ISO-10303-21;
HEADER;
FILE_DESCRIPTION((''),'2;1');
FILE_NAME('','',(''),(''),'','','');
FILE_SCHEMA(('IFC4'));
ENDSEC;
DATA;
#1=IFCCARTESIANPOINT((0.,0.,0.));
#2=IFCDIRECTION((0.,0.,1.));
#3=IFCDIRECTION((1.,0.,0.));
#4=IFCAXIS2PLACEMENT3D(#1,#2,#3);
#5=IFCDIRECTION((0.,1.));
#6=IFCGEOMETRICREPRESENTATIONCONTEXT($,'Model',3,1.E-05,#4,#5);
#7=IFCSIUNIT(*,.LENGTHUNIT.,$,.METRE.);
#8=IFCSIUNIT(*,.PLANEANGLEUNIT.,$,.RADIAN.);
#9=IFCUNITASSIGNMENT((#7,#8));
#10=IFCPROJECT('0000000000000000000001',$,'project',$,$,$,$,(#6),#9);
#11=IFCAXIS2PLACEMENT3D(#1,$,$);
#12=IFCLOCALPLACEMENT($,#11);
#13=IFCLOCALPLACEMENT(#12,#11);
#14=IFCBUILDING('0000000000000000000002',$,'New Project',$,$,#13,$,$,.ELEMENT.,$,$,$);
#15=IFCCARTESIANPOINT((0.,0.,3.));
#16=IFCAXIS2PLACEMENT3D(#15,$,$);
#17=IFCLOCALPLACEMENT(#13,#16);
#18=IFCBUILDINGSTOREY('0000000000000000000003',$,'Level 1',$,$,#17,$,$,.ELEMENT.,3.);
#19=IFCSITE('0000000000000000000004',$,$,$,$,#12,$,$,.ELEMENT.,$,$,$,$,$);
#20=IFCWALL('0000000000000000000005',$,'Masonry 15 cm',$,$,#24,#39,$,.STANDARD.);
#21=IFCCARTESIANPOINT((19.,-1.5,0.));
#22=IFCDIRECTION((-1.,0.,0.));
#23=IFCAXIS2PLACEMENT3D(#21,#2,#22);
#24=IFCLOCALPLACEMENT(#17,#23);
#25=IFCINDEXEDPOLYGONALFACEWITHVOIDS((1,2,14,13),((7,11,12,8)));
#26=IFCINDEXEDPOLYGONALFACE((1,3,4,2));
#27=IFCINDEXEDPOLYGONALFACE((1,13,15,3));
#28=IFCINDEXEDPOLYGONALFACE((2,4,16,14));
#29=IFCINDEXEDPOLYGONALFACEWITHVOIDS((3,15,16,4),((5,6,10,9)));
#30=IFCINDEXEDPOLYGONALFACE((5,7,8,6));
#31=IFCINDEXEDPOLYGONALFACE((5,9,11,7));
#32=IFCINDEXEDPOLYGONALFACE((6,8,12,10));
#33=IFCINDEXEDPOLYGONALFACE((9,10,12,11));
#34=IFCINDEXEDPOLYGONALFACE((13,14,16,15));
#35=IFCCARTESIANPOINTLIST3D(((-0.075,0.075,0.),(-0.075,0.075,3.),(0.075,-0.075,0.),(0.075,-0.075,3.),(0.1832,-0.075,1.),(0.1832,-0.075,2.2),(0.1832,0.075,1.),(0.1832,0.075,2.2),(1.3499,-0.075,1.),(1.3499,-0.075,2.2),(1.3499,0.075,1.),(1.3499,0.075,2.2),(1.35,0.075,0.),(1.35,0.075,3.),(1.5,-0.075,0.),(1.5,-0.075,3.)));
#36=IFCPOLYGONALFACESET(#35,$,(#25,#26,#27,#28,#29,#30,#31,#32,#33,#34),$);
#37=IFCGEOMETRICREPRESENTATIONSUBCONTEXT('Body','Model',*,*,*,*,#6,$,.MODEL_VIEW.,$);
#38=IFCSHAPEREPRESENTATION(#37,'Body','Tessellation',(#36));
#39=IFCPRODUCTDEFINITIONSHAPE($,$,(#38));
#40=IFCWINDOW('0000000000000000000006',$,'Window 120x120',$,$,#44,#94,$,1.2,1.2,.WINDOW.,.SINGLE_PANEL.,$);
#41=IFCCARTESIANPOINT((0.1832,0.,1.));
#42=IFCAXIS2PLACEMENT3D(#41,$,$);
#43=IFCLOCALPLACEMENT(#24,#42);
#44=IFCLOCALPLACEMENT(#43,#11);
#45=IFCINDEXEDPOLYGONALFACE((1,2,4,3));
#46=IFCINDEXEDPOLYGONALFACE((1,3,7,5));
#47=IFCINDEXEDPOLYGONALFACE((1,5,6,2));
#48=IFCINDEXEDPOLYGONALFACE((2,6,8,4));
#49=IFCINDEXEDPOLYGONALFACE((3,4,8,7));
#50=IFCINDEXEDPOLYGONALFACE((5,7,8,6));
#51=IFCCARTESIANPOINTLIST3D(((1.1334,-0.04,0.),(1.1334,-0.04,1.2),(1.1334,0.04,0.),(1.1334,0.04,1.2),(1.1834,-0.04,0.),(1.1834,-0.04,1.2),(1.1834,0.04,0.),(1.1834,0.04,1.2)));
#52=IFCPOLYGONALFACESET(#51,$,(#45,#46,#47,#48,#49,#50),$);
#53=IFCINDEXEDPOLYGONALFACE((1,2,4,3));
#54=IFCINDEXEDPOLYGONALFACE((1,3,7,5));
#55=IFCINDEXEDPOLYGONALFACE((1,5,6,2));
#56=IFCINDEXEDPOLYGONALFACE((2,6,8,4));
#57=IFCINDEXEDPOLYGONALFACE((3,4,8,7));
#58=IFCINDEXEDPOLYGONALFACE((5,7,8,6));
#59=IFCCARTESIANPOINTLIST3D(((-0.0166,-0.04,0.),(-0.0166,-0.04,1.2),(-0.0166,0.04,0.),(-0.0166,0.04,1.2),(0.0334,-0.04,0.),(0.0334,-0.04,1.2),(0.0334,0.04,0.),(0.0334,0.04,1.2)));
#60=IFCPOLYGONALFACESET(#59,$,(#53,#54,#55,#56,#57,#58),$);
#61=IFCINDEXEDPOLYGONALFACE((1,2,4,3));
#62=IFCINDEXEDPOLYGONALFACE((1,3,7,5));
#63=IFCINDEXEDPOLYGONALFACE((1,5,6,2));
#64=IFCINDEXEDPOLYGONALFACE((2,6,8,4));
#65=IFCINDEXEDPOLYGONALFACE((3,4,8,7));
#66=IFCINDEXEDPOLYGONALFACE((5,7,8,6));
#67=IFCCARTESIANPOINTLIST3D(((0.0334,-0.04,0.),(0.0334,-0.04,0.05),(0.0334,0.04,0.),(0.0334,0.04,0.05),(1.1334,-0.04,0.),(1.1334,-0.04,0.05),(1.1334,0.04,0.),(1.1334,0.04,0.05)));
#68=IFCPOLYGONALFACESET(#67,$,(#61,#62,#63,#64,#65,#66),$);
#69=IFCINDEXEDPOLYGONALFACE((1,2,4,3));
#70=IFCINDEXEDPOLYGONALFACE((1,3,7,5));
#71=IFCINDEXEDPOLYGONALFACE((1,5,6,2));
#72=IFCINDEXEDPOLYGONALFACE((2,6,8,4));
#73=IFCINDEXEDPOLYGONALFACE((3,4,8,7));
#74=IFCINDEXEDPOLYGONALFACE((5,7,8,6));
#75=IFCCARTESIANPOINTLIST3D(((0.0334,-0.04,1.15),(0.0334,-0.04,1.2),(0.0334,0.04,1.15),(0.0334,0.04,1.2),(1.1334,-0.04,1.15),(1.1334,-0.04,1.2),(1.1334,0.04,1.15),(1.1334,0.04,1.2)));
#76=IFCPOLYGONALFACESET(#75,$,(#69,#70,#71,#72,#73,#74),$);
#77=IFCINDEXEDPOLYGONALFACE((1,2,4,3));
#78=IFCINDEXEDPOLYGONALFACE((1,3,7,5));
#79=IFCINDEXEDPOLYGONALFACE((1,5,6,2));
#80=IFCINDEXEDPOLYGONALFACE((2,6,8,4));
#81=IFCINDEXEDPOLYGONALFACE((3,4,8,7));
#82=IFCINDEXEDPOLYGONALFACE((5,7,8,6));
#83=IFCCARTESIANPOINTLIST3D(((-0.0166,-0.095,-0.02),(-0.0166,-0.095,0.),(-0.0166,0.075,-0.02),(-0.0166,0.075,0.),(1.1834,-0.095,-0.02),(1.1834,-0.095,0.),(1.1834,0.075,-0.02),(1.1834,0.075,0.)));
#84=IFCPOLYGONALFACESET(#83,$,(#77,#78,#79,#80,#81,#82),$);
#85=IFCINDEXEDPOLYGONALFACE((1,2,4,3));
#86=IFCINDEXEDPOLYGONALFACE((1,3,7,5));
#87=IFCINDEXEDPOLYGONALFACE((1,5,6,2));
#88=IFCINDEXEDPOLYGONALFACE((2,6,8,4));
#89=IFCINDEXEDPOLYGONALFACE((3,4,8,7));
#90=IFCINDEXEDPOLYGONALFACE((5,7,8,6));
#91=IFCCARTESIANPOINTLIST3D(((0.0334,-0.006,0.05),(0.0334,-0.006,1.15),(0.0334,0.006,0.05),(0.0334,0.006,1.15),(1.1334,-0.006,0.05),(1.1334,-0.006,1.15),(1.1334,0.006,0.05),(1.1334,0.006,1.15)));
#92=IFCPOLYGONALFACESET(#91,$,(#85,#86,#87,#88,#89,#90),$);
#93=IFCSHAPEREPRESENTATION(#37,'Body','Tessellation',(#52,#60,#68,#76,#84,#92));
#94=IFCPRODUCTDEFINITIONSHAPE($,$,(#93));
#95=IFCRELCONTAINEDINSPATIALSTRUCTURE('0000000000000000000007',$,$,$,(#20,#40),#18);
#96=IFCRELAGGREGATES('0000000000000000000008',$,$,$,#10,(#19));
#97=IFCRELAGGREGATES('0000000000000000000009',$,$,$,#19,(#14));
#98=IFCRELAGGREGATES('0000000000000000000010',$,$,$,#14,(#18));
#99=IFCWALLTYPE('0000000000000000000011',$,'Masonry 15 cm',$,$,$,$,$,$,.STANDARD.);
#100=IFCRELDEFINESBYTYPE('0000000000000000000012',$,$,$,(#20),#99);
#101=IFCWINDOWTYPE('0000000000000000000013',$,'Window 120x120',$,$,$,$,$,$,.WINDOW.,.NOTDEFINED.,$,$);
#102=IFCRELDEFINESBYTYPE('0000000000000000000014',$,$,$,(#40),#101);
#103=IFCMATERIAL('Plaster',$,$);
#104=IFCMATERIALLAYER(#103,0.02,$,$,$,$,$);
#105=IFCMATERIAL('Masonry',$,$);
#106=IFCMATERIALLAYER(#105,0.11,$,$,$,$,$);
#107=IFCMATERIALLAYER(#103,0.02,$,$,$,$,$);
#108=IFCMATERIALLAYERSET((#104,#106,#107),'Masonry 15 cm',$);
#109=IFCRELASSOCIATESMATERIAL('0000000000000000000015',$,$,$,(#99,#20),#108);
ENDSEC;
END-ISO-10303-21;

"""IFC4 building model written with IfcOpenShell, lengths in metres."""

from ifc_helpers import new_model, si_unit, direction, frame, frame_2d, origin, origin_with_axes, place, context, subcontext, project, spatial, polyline, rectangle, outline, extrude, material, layer, layer_set, layer_usage, type_object, element, fill, save


model = new_model("IFC4")

# Units and contexts
model_context = context("Model", 3, precision=1e-05, world=origin_with_axes(), true_north=direction((0.0, 1.0)))
body_context = subcontext(model_context, "Body", "Model", "MODEL_VIEW")
ifc_project = project(units=[si_unit("LENGTHUNIT", "METRE"), si_unit("PLANEANGLEUNIT", "RADIAN")], contexts=[model_context])

# Site, building, storey
site_placement = place(None, origin())
site = spatial("IfcSite", under=ifc_project, at=site_placement, CompositionType="ELEMENT")
building_placement = place(site_placement, origin())
building = spatial("IfcBuilding", under=site, at=building_placement, Name="New Project", CompositionType="ELEMENT")
storey_placement = place(building_placement, frame((0.0, 0.0, 3.0)))
storey = spatial("IfcBuildingStorey", under=building, at=storey_placement, Name="Level 1", CompositionType="ELEMENT", Elevation=3.0)

# Shared definitions
ifc_material_1 = material(Name="Plaster")
ifc_layer_1 = layer(ifc_material_1, 0.02)
ifc_material_2 = material(Name="Masonry")
ifc_layer_2 = layer(ifc_material_2, 0.11)
ifc_layer_3 = layer(ifc_material_1, 0.02)
ifc_layer_set_1 = layer_set([ifc_layer_1, ifc_layer_2, ifc_layer_3], Name="Masonry 15 cm")
ifc_layer_usage_1 = layer_usage(ifc_layer_set_1, "AXIS2", "NEGATIVE", 0.075)
wall_type_1 = type_object("IfcWallType", Name="Masonry 15 cm", PredefinedType="STANDARD", material=ifc_layer_set_1)

# Shared definitions
window_type_1 = type_object("IfcWindowType", Name="Window 120x120", PartitioningType="NOTDEFINED", PredefinedType="WINDOW")

# Wall, opening, window
wall_1_placement = place(storey_placement, frame((19.0, -1.5, 0.0), z_axis=(0.0, 0.0, 1.0), x_axis=(-1.0, 0.0, 0.0)))
wall_1 = element("IfcWall", 1, at=wall_1_placement, inside=storey, type_object=wall_type_1, material=ifc_layer_usage_1, Name="Masonry 15 cm", PredefinedType="STANDARD", context=body_context, shape_type="SweptSolid", body=[
    extrude(outline(polyline([(0.075, -0.075), (1.5, -0.075), (1.35, 0.075), (-0.075, 0.075), (0.075, -0.075)])), origin(), (0.0, 0.0, 1.0), 3.0),
])
opening_1_placement = place(wall_1_placement, frame((0.1832, 0.0, 1.0)))
opening_1 = element("IfcOpeningElement", 2, at=opening_1_placement, cuts=wall_1, PredefinedType="OPENING", context=body_context, shape_type="SweptSolid", body=[
    extrude(rectangle(XDim=1.1667, YDim=0.25, at=frame_2d((0.5834, 0.0))), origin(), (0.0, 0.0, 1.0), 1.2),
])
window_1_placement = place(opening_1_placement, origin())
window_1 = element("IfcWindow", 3, at=window_1_placement, inside=storey, type_object=window_type_1, Name="Window 120x120", OverallHeight=1.2, OverallWidth=1.2, PartitioningType="SINGLE_PANEL", PredefinedType="WINDOW", context=body_context, shape_type="SweptSolid", body=[
    extrude(outline(polyline([(1.1834, 0.04), (1.1334, 0.04), (1.1334, -0.04), (1.1834, -0.04), (1.1834, 0.04)])), origin(), (0.0, 0.0, 1.0), 1.2),
    extrude(outline(polyline([(0.0334, 0.04), (-0.0166, 0.04), (-0.0166, -0.04), (0.0334, -0.04), (0.0334, 0.04)])), origin(), (0.0, 0.0, 1.0), 1.2),
    extrude(outline(polyline([(1.1334, 0.04), (0.0334, 0.04), (0.0334, -0.04), (1.1334, -0.04), (1.1334, 0.04)])), origin(), (0.0, 0.0, 1.0), 0.05),
    extrude(outline(polyline([(1.1334, 0.04), (0.0334, 0.04), (0.0334, -0.04), (1.1334, -0.04), (1.1334, 0.04)])), frame((0.0, 0.0, 1.15)), (0.0, 0.0, 1.0), 0.05),
    extrude(outline(polyline([(1.1834, 0.075), (-0.0166, 0.075), (-0.0166, -0.095), (1.1834, -0.095), (1.1834, 0.075)])), frame((0.0, 0.0, -0.02)), (0.0, 0.0, 1.0), 0.02),
    extrude(outline(polyline([(1.1334, 0.006), (0.0334, 0.006), (0.0334, -0.006), (1.1334, -0.006), (1.1334, 0.006)])), frame((0.0, 0.0, 0.05)), (0.0, 0.0, 1.0), 1.1),
])
fill(opening_1, window_1)

save(model, "model.ifc")
